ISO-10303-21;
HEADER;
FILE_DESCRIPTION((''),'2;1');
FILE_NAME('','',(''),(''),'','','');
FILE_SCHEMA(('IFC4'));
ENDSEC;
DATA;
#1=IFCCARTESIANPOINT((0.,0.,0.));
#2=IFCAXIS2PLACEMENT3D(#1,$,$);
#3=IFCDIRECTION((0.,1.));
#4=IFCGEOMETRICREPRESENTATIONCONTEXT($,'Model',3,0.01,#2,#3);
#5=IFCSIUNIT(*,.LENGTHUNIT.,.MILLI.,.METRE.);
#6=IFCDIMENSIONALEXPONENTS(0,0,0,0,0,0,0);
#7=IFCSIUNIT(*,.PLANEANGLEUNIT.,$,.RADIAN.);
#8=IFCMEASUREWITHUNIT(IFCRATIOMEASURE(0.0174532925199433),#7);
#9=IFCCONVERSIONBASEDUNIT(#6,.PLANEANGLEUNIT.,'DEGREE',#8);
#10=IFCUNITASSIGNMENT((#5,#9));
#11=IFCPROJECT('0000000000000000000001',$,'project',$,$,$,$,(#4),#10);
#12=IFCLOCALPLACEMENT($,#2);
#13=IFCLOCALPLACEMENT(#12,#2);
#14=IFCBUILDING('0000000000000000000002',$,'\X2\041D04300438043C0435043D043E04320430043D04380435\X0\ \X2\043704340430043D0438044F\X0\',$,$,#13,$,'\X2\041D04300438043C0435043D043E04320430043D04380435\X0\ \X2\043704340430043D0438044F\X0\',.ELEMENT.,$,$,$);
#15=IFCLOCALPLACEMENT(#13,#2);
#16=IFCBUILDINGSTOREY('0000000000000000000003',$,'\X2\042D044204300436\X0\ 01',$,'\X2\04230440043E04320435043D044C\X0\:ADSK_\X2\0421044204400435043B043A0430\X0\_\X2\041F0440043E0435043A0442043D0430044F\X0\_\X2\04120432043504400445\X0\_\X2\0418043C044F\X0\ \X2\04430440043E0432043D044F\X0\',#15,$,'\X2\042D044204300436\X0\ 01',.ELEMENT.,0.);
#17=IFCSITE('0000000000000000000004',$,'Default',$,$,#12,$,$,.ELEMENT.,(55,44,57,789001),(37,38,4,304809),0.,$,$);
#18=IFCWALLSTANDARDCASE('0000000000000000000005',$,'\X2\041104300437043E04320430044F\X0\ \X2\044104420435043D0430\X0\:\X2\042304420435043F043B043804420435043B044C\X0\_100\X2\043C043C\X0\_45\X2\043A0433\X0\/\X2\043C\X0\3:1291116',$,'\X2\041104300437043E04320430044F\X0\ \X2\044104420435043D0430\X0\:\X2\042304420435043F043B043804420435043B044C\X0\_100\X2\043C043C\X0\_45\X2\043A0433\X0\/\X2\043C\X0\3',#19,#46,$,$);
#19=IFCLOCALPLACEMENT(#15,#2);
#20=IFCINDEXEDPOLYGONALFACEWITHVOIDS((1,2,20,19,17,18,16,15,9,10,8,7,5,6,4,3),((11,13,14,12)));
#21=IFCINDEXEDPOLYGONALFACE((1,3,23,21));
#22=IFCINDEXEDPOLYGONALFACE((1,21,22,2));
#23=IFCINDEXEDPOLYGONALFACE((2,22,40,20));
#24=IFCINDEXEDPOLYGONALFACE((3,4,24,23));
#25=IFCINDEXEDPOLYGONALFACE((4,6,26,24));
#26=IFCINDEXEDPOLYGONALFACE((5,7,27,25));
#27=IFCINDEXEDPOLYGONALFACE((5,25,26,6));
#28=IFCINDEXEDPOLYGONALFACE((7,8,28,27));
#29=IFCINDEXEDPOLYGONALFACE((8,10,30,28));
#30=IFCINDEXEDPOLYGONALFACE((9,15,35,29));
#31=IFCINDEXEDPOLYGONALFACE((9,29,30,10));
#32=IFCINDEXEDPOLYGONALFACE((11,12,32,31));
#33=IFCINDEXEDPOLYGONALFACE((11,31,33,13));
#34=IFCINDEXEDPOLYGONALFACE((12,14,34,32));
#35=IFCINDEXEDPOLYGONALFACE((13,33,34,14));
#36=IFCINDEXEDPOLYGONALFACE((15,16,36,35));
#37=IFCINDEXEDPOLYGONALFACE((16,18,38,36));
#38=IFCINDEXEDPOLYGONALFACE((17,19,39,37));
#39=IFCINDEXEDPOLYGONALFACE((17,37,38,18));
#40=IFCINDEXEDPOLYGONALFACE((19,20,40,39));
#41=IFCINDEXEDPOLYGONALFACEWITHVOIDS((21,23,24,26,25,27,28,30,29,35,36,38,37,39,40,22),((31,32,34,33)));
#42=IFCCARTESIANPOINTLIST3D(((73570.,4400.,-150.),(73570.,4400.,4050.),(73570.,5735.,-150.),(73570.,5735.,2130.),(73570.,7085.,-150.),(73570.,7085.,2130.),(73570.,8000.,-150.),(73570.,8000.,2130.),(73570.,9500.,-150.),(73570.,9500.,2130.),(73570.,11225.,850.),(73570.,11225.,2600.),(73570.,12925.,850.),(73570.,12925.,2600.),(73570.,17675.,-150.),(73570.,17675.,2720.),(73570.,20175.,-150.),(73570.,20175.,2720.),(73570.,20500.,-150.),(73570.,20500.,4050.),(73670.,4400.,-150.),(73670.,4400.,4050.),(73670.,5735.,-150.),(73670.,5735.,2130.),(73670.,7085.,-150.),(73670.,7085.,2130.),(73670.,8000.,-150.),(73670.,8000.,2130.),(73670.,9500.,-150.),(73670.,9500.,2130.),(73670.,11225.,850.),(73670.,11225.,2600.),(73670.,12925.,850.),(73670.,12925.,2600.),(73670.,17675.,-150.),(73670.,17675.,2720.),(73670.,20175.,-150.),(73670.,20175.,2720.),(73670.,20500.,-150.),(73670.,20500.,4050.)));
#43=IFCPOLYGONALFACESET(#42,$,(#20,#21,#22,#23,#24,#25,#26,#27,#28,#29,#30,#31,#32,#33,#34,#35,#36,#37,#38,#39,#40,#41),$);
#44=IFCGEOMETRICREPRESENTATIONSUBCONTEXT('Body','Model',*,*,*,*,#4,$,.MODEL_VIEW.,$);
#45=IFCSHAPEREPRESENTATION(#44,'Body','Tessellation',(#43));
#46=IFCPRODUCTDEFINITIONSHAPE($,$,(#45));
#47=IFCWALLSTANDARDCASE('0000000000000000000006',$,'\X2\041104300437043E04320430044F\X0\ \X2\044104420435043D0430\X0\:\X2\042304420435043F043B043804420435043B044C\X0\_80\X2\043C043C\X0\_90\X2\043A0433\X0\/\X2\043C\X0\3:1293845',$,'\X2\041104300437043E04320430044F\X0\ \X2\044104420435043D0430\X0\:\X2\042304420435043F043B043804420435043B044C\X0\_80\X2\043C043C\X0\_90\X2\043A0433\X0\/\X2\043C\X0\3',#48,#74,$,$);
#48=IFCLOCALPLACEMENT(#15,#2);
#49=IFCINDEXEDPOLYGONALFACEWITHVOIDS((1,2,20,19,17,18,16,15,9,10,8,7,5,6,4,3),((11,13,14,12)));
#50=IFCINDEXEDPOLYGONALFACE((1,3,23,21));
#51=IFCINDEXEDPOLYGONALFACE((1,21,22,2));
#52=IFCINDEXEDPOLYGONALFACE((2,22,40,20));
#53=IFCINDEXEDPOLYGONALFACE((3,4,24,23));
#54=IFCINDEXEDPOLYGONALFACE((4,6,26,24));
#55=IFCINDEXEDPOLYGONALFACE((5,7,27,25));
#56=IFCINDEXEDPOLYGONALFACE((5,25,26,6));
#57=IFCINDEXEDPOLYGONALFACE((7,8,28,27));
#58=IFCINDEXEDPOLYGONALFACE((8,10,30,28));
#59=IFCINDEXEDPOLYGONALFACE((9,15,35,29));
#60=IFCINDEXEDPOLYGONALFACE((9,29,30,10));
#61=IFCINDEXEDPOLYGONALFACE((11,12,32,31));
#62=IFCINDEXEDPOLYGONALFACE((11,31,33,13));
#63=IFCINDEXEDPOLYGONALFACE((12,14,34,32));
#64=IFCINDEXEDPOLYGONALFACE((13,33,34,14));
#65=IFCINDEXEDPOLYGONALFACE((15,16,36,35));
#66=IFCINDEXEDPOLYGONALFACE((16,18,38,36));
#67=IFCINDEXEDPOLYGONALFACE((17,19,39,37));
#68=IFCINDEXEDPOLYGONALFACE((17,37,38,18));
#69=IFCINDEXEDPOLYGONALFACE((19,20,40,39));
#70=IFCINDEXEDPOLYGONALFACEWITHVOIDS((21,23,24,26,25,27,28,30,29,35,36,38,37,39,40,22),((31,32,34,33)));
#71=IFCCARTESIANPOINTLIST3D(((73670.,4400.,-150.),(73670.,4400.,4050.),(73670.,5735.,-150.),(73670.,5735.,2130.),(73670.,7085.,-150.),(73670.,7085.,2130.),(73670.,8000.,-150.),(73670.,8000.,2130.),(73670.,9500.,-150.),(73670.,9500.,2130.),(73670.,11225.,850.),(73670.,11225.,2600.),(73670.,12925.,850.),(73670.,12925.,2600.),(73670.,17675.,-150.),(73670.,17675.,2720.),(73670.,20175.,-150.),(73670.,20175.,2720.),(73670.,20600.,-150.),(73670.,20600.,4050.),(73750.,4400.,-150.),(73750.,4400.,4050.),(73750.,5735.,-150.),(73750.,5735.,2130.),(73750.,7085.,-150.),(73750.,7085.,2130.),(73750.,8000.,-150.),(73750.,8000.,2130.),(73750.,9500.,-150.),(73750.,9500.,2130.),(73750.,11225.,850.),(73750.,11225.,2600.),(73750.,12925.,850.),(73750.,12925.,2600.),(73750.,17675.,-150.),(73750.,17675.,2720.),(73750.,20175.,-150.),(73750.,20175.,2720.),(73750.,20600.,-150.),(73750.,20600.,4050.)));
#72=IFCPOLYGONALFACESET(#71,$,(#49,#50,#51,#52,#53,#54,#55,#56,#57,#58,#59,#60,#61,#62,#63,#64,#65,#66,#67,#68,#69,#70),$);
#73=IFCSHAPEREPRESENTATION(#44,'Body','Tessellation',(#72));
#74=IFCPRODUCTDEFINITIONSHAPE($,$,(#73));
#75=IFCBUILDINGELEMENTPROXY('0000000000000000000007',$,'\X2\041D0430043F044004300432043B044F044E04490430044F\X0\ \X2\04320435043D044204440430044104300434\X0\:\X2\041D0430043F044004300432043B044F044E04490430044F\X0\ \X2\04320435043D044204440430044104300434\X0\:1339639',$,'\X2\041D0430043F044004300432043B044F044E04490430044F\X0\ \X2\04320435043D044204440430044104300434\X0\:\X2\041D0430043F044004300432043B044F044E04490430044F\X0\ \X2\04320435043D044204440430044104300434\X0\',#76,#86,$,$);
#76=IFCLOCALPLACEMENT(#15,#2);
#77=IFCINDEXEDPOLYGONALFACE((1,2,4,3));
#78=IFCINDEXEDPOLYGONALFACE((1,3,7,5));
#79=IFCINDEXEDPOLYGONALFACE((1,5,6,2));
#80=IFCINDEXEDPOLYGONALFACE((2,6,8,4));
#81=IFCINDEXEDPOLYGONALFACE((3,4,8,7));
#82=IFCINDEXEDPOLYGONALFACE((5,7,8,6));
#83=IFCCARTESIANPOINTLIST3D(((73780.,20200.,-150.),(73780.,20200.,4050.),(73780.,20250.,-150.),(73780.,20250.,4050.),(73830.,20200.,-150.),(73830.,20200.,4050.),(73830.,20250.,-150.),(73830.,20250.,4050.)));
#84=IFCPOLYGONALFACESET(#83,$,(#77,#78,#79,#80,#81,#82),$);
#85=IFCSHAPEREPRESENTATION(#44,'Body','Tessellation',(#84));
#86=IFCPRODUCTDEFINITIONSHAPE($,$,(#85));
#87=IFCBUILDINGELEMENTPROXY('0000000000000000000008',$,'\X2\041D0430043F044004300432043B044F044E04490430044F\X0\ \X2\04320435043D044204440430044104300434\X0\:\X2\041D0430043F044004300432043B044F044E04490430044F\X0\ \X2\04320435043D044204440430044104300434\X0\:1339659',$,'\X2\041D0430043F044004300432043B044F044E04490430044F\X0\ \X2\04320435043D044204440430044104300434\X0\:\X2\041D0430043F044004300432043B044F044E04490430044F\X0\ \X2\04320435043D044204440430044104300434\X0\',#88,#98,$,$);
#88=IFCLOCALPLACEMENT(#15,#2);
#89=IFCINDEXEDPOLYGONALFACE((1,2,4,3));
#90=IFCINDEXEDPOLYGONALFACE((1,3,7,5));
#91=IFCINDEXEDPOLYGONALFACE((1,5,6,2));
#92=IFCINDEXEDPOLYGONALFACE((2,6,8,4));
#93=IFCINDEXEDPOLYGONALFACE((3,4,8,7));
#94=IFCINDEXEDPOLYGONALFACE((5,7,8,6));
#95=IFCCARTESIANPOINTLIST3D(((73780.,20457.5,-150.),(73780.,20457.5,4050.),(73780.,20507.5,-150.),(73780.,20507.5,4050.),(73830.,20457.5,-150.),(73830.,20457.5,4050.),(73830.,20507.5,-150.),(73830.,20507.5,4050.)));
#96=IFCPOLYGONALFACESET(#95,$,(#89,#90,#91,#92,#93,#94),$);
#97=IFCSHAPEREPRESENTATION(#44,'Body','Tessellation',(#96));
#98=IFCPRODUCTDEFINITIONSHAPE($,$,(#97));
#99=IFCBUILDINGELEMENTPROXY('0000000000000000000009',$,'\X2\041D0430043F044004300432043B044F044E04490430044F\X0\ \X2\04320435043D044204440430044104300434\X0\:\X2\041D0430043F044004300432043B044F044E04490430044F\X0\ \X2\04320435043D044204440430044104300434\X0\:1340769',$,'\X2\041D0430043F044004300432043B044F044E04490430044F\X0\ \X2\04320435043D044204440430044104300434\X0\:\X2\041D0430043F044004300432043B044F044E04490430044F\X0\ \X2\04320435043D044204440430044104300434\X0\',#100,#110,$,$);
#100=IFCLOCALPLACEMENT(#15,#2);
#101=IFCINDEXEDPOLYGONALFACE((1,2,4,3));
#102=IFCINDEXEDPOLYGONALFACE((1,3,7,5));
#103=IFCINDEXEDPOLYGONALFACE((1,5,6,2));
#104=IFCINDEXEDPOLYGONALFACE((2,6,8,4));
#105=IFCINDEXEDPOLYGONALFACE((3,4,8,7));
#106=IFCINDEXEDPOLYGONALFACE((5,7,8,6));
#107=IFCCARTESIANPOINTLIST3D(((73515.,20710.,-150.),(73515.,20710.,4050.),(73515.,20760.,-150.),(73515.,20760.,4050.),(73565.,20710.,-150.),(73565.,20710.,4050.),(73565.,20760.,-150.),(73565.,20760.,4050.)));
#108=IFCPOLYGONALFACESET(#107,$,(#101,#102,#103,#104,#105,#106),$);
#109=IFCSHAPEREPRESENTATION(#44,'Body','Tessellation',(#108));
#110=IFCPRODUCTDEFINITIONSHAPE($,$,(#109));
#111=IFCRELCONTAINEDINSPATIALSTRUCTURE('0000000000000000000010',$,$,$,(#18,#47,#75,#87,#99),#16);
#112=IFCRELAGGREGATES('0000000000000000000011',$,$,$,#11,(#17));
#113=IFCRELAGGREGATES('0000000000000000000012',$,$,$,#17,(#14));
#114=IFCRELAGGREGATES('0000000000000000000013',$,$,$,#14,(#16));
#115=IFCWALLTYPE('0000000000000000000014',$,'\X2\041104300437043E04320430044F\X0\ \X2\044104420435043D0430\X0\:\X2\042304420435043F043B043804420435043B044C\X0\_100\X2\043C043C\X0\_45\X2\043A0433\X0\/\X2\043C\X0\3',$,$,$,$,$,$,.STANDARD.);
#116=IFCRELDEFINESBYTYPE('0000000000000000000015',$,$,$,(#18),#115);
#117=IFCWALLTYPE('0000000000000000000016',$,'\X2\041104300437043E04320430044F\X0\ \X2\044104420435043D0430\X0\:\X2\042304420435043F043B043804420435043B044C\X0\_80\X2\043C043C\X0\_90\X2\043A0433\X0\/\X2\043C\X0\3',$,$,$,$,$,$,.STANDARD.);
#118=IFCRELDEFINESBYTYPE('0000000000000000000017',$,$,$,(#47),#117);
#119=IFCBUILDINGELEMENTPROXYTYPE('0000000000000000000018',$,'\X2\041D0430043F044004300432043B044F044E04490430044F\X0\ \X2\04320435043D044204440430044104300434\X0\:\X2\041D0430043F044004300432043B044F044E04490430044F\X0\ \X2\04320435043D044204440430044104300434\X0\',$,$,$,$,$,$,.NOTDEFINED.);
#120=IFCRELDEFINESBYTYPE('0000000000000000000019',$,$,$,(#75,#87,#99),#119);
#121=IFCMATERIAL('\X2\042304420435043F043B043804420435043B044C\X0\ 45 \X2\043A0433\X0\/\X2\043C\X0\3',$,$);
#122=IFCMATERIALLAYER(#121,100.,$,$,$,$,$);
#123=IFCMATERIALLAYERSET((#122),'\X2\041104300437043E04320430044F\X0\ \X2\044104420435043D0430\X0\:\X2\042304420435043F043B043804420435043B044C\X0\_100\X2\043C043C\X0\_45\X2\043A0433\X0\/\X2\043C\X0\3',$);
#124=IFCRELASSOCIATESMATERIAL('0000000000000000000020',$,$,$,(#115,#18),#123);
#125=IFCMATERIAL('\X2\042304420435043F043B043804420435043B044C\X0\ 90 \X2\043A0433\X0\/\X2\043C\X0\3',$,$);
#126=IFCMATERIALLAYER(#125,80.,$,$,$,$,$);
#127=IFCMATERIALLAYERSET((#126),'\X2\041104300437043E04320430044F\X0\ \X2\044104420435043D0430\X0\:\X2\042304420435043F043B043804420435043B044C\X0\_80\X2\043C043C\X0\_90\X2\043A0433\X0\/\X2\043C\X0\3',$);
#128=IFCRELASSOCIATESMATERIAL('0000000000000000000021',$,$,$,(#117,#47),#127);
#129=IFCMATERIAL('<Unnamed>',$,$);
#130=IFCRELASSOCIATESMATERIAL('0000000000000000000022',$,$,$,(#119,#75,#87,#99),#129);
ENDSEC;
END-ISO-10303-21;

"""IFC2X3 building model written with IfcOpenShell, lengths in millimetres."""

from ifc_helpers import new_model, entity, si_unit, converted_unit, direction, frame, frame_2d, origin, origin_2d_with_axis, place, context, subcontext, project, spatial, rectangle, extrude, source, transform, mapped, material, layer, layer_set, layer_usage, type_object, type_shapes, element, save


model = new_model("IFC2X3")

# Units and contexts
model_context = context("Model", 3, precision=0.01, world=origin(), true_north=direction((0.0, 1.0)))
body_context = subcontext(model_context, "Body", "Model", "MODEL_VIEW")
ifc_project = project(units=[si_unit("LENGTHUNIT", "METRE", prefix="MILLI"), converted_unit("PLANEANGLEUNIT", "DEGREE", entity("IfcRatioMeasure", 0.0174532925199433), si_unit("PLANEANGLEUNIT", "RADIAN"), dimensions=[0, 0, 0, 0, 0, 0, 0])], contexts=[model_context])

# Site, building, storey
site_placement = place(None, origin())
site = spatial("IfcSite", under=ifc_project, at=site_placement, Name="Default", CompositionType="ELEMENT", RefLatitude=(55, 44, 57, 789001), RefLongitude=(37, 38, 4, 304809), RefElevation=0.0)
building_placement = place(site_placement, origin())
building = spatial("IfcBuilding", under=site, at=building_placement, Name="Наименование здания", LongName="Наименование здания", CompositionType="ELEMENT")
storey_placement = place(building_placement, origin())
storey = spatial("IfcBuildingStorey", under=building, at=storey_placement, Name="Этаж 01", ObjectType="Уровень:ADSK_Стрелка_Проектная_Вверх_Имя уровня", LongName="Этаж 01", CompositionType="ELEMENT", Elevation=0.0)

# Walls, openings
ifc_material_1 = material(Name="Утеплитель 45 кг/м3")
ifc_layer_1 = layer(ifc_material_1, 100.0)
ifc_layer_set_1 = layer_set([ifc_layer_1], Name="Базовая стена:Утеплитель_100мм_45кг/м3")
ifc_layer_usage_1 = layer_usage(ifc_layer_set_1, "AXIS2", "NEGATIVE", 50.0)
wall_type_1 = type_object("IfcWallType", Name="Базовая стена:Утеплитель_100мм_45кг/м3", PredefinedType="STANDARD", material=ifc_layer_set_1)
wall_1_placement = place(storey_placement, frame((73620.0, 20500.0, -150.0), z_axis=(0.0, 0.0, 1.0), x_axis=(0.0, -1.0, 0.0)))
wall_1 = element("IfcWallStandardCase", 1, at=wall_1_placement, inside=storey, type_object=wall_type_1, material=ifc_layer_usage_1, Name="Базовая стена:Утеплитель_100мм_45кг/м3:1291116", ObjectType="Базовая стена:Утеплитель_100мм_45кг/м3", context=body_context, shape_type="SweptSolid", body=[
    extrude(rectangle(XDim=16100.0, YDim=100.0, at=frame_2d((8050.0, 0.0), x_axis=(-1.0, 0.0))), origin(), (0.0, 0.0, 1.0), 4200.0),
])
opening_1_placement = place(wall_1_placement, origin())
element("IfcOpeningElement", 2, at=opening_1_placement, cuts=wall_1, ObjectType="Opening", context=body_context, shape_type="SweptSolid", body=[
    extrude(rectangle(XDim=1750.0, YDim=1700.0, at=frame_2d((0.0, 0.0), x_axis=(0.0, 1.0))), frame((8425.0, 50.0, 1875.0), z_axis=(0.0, -1.0, 0.0), x_axis=(-1.0, 0.0, 0.0)), (0.0, 0.0, 1.0), 100.0),
])
opening_2_placement = place(wall_1_placement, origin())
element("IfcOpeningElement", 3, at=opening_2_placement, cuts=wall_1, ObjectType="Opening", context=body_context, shape_type="SweptSolid", body=[
    extrude(rectangle(XDim=2280.0, YDim=1500.0, at=frame_2d((0.0, 0.0), x_axis=(0.0, 1.0))), frame((11750.0, 50.0, 1140.0), z_axis=(0.0, -1.0, 0.0), x_axis=(1.0, 0.0, 0.0)), (0.0, 0.0, 1.0), 100.0),
])
opening_3_placement = place(wall_1_placement, origin())
element("IfcOpeningElement", 4, at=opening_3_placement, cuts=wall_1, ObjectType="Opening", context=body_context, shape_type="SweptSolid", body=[
    extrude(rectangle(XDim=2280.0, YDim=1350.0, at=frame_2d((0.0, 0.0), x_axis=(0.0, 1.0))), frame((14090.0, 50.0, 1140.0), z_axis=(0.0, -1.0, 0.0), x_axis=(1.0, 0.0, 0.0)), (0.0, 0.0, 1.0), 100.0),
])
opening_4_placement = place(wall_1_placement, origin())
element("IfcOpeningElement", 5, at=opening_4_placement, cuts=wall_1, ObjectType="Opening", context=body_context, shape_type="SweptSolid", body=[
    extrude(rectangle(XDim=2870.0, YDim=2500.0, at=frame_2d((0.0, 0.0), x_axis=(0.0, 1.0))), frame((1575.0, 50.0, 1435.0), z_axis=(0.0, -1.0, 0.0), x_axis=(1.0, 0.0, 0.0)), (0.0, 0.0, 1.0), 100.0),
])
ifc_material_2 = material(Name="Утеплитель 90 кг/м3")
ifc_layer_2 = layer(ifc_material_2, 80.0)
ifc_layer_set_2 = layer_set([ifc_layer_2], Name="Базовая стена:Утеплитель_80мм_90кг/м3")
ifc_layer_usage_2 = layer_usage(ifc_layer_set_2, "AXIS2", "NEGATIVE", 40.0)
wall_type_2 = type_object("IfcWallType", Name="Базовая стена:Утеплитель_80мм_90кг/м3", PredefinedType="STANDARD", material=ifc_layer_set_2)
wall_2_placement = place(storey_placement, frame((73710.0, 20600.0, -150.0), z_axis=(0.0, 0.0, 1.0), x_axis=(0.0, -1.0, 0.0)))
wall_2 = element("IfcWallStandardCase", 6, at=wall_2_placement, inside=storey, type_object=wall_type_2, material=ifc_layer_usage_2, Name="Базовая стена:Утеплитель_80мм_90кг/м3:1293845", ObjectType="Базовая стена:Утеплитель_80мм_90кг/м3", context=body_context, shape_type="SweptSolid", body=[
    extrude(rectangle(XDim=16200.0, YDim=80.0, at=frame_2d((8100.0, 0.0), x_axis=(-1.0, 0.0))), origin(), (0.0, 0.0, 1.0), 4200.0),
])
opening_5_placement = place(wall_2_placement, origin())
element("IfcOpeningElement", 7, at=opening_5_placement, cuts=wall_2, ObjectType="Opening", context=body_context, shape_type="SweptSolid", body=[
    extrude(rectangle(XDim=1750.0, YDim=1700.0, at=frame_2d((0.0, 0.0), x_axis=(0.0, 1.0))), frame((8525.0, 40.0, 1875.0), z_axis=(0.0, -1.0, 0.0), x_axis=(-1.0, 0.0, 0.0)), (0.0, 0.0, 1.0), 80.0),
])
opening_6_placement = place(wall_2_placement, origin())
element("IfcOpeningElement", 8, at=opening_6_placement, cuts=wall_2, ObjectType="Opening", context=body_context, shape_type="SweptSolid", body=[
    extrude(rectangle(XDim=2280.0, YDim=1500.0, at=frame_2d((0.0, 0.0), x_axis=(0.0, 1.0))), frame((11850.0, 40.0, 1140.0), z_axis=(0.0, -1.0, 0.0), x_axis=(1.0, 0.0, 0.0)), (0.0, 0.0, 1.0), 80.0),
])
opening_7_placement = place(wall_2_placement, origin())
element("IfcOpeningElement", 9, at=opening_7_placement, cuts=wall_2, ObjectType="Opening", context=body_context, shape_type="SweptSolid", body=[
    extrude(rectangle(XDim=2280.0, YDim=1350.0, at=frame_2d((0.0, 0.0), x_axis=(0.0, 1.0))), frame((14190.0, 40.0, 1140.0), z_axis=(0.0, -1.0, 0.0), x_axis=(1.0, 0.0, 0.0)), (0.0, 0.0, 1.0), 80.0),
])
opening_8_placement = place(wall_2_placement, origin())
element("IfcOpeningElement", 10, at=opening_8_placement, cuts=wall_2, ObjectType="Opening", context=body_context, shape_type="SweptSolid", body=[
    extrude(rectangle(XDim=2870.0, YDim=2500.0, at=frame_2d((0.0, 0.0), x_axis=(0.0, 1.0))), frame((1675.0, 40.0, 1435.0), z_axis=(0.0, -1.0, 0.0), x_axis=(1.0, 0.0, 0.0)), (0.0, 0.0, 1.0), 80.0),
])

# Building element proxies
ifc_material_3 = material(Name="<Unnamed>")
building_element_proxy_type_1 = type_object("IfcBuildingElementProxyType", Name="Направляющая вентфасад:Направляющая вентфасад", PredefinedType="NOTDEFINED", material=ifc_material_3)
shared_shape_1 = source(origin(), body_context, "Body", "SweptSolid", [
    extrude(rectangle(XDim=50.0, YDim=50.0, at=origin_2d_with_axis()), frame((25.0, 25.0, 0.0), z_axis=(0.0, 0.0, 1.0), x_axis=(0.0, 1.0, 0.0)), (0.0, 0.0, 1.0), 4200.0),
])
type_shapes(building_element_proxy_type_1, [shared_shape_1])
for number, where, z_axis, x_axis, name in (
    (11, (73780.0, 20250.0, -150.0), (0.0, 0.0, 1.0), (-0.000006, -1.0, 0.0), "Направляющая вентфасад:Направляющая вентфасад:1339639"),
    (12, (73780.0, 20507.5, -150.0), (0.0, 0.0, 1.0), (-0.000006, -1.0, 0.0), "Направляющая вентфасад:Направляющая вентфасад:1339659"),
):
    element("IfcBuildingElementProxy", number, at=place(storey_placement, frame(where, z_axis=z_axis, x_axis=x_axis)), inside=storey, type_object=building_element_proxy_type_1, material=ifc_material_3, Name=name, ObjectType="Направляющая вентфасад:Направляющая вентфасад", context=body_context, shape_type="MappedRepresentation", body=[
        mapped(shared_shape_1, transform((0.0, 0.0, 0.0), scale=1.0)),
    ])
proxy_1_placement = place(storey_placement, frame((73515.0, 20710.0, -150.0)))
element("IfcBuildingElementProxy", 13, at=proxy_1_placement, inside=storey, type_object=building_element_proxy_type_1, material=ifc_material_3, Name="Направляющая вентфасад:Направляющая вентфасад:1340769", ObjectType="Направляющая вентфасад:Направляющая вентфасад", context=body_context, shape_type="MappedRepresentation", body=[
    mapped(shared_shape_1, transform((0.0, 0.0, 0.0), scale=1.0)),
])

save(model, "model.ifc")
